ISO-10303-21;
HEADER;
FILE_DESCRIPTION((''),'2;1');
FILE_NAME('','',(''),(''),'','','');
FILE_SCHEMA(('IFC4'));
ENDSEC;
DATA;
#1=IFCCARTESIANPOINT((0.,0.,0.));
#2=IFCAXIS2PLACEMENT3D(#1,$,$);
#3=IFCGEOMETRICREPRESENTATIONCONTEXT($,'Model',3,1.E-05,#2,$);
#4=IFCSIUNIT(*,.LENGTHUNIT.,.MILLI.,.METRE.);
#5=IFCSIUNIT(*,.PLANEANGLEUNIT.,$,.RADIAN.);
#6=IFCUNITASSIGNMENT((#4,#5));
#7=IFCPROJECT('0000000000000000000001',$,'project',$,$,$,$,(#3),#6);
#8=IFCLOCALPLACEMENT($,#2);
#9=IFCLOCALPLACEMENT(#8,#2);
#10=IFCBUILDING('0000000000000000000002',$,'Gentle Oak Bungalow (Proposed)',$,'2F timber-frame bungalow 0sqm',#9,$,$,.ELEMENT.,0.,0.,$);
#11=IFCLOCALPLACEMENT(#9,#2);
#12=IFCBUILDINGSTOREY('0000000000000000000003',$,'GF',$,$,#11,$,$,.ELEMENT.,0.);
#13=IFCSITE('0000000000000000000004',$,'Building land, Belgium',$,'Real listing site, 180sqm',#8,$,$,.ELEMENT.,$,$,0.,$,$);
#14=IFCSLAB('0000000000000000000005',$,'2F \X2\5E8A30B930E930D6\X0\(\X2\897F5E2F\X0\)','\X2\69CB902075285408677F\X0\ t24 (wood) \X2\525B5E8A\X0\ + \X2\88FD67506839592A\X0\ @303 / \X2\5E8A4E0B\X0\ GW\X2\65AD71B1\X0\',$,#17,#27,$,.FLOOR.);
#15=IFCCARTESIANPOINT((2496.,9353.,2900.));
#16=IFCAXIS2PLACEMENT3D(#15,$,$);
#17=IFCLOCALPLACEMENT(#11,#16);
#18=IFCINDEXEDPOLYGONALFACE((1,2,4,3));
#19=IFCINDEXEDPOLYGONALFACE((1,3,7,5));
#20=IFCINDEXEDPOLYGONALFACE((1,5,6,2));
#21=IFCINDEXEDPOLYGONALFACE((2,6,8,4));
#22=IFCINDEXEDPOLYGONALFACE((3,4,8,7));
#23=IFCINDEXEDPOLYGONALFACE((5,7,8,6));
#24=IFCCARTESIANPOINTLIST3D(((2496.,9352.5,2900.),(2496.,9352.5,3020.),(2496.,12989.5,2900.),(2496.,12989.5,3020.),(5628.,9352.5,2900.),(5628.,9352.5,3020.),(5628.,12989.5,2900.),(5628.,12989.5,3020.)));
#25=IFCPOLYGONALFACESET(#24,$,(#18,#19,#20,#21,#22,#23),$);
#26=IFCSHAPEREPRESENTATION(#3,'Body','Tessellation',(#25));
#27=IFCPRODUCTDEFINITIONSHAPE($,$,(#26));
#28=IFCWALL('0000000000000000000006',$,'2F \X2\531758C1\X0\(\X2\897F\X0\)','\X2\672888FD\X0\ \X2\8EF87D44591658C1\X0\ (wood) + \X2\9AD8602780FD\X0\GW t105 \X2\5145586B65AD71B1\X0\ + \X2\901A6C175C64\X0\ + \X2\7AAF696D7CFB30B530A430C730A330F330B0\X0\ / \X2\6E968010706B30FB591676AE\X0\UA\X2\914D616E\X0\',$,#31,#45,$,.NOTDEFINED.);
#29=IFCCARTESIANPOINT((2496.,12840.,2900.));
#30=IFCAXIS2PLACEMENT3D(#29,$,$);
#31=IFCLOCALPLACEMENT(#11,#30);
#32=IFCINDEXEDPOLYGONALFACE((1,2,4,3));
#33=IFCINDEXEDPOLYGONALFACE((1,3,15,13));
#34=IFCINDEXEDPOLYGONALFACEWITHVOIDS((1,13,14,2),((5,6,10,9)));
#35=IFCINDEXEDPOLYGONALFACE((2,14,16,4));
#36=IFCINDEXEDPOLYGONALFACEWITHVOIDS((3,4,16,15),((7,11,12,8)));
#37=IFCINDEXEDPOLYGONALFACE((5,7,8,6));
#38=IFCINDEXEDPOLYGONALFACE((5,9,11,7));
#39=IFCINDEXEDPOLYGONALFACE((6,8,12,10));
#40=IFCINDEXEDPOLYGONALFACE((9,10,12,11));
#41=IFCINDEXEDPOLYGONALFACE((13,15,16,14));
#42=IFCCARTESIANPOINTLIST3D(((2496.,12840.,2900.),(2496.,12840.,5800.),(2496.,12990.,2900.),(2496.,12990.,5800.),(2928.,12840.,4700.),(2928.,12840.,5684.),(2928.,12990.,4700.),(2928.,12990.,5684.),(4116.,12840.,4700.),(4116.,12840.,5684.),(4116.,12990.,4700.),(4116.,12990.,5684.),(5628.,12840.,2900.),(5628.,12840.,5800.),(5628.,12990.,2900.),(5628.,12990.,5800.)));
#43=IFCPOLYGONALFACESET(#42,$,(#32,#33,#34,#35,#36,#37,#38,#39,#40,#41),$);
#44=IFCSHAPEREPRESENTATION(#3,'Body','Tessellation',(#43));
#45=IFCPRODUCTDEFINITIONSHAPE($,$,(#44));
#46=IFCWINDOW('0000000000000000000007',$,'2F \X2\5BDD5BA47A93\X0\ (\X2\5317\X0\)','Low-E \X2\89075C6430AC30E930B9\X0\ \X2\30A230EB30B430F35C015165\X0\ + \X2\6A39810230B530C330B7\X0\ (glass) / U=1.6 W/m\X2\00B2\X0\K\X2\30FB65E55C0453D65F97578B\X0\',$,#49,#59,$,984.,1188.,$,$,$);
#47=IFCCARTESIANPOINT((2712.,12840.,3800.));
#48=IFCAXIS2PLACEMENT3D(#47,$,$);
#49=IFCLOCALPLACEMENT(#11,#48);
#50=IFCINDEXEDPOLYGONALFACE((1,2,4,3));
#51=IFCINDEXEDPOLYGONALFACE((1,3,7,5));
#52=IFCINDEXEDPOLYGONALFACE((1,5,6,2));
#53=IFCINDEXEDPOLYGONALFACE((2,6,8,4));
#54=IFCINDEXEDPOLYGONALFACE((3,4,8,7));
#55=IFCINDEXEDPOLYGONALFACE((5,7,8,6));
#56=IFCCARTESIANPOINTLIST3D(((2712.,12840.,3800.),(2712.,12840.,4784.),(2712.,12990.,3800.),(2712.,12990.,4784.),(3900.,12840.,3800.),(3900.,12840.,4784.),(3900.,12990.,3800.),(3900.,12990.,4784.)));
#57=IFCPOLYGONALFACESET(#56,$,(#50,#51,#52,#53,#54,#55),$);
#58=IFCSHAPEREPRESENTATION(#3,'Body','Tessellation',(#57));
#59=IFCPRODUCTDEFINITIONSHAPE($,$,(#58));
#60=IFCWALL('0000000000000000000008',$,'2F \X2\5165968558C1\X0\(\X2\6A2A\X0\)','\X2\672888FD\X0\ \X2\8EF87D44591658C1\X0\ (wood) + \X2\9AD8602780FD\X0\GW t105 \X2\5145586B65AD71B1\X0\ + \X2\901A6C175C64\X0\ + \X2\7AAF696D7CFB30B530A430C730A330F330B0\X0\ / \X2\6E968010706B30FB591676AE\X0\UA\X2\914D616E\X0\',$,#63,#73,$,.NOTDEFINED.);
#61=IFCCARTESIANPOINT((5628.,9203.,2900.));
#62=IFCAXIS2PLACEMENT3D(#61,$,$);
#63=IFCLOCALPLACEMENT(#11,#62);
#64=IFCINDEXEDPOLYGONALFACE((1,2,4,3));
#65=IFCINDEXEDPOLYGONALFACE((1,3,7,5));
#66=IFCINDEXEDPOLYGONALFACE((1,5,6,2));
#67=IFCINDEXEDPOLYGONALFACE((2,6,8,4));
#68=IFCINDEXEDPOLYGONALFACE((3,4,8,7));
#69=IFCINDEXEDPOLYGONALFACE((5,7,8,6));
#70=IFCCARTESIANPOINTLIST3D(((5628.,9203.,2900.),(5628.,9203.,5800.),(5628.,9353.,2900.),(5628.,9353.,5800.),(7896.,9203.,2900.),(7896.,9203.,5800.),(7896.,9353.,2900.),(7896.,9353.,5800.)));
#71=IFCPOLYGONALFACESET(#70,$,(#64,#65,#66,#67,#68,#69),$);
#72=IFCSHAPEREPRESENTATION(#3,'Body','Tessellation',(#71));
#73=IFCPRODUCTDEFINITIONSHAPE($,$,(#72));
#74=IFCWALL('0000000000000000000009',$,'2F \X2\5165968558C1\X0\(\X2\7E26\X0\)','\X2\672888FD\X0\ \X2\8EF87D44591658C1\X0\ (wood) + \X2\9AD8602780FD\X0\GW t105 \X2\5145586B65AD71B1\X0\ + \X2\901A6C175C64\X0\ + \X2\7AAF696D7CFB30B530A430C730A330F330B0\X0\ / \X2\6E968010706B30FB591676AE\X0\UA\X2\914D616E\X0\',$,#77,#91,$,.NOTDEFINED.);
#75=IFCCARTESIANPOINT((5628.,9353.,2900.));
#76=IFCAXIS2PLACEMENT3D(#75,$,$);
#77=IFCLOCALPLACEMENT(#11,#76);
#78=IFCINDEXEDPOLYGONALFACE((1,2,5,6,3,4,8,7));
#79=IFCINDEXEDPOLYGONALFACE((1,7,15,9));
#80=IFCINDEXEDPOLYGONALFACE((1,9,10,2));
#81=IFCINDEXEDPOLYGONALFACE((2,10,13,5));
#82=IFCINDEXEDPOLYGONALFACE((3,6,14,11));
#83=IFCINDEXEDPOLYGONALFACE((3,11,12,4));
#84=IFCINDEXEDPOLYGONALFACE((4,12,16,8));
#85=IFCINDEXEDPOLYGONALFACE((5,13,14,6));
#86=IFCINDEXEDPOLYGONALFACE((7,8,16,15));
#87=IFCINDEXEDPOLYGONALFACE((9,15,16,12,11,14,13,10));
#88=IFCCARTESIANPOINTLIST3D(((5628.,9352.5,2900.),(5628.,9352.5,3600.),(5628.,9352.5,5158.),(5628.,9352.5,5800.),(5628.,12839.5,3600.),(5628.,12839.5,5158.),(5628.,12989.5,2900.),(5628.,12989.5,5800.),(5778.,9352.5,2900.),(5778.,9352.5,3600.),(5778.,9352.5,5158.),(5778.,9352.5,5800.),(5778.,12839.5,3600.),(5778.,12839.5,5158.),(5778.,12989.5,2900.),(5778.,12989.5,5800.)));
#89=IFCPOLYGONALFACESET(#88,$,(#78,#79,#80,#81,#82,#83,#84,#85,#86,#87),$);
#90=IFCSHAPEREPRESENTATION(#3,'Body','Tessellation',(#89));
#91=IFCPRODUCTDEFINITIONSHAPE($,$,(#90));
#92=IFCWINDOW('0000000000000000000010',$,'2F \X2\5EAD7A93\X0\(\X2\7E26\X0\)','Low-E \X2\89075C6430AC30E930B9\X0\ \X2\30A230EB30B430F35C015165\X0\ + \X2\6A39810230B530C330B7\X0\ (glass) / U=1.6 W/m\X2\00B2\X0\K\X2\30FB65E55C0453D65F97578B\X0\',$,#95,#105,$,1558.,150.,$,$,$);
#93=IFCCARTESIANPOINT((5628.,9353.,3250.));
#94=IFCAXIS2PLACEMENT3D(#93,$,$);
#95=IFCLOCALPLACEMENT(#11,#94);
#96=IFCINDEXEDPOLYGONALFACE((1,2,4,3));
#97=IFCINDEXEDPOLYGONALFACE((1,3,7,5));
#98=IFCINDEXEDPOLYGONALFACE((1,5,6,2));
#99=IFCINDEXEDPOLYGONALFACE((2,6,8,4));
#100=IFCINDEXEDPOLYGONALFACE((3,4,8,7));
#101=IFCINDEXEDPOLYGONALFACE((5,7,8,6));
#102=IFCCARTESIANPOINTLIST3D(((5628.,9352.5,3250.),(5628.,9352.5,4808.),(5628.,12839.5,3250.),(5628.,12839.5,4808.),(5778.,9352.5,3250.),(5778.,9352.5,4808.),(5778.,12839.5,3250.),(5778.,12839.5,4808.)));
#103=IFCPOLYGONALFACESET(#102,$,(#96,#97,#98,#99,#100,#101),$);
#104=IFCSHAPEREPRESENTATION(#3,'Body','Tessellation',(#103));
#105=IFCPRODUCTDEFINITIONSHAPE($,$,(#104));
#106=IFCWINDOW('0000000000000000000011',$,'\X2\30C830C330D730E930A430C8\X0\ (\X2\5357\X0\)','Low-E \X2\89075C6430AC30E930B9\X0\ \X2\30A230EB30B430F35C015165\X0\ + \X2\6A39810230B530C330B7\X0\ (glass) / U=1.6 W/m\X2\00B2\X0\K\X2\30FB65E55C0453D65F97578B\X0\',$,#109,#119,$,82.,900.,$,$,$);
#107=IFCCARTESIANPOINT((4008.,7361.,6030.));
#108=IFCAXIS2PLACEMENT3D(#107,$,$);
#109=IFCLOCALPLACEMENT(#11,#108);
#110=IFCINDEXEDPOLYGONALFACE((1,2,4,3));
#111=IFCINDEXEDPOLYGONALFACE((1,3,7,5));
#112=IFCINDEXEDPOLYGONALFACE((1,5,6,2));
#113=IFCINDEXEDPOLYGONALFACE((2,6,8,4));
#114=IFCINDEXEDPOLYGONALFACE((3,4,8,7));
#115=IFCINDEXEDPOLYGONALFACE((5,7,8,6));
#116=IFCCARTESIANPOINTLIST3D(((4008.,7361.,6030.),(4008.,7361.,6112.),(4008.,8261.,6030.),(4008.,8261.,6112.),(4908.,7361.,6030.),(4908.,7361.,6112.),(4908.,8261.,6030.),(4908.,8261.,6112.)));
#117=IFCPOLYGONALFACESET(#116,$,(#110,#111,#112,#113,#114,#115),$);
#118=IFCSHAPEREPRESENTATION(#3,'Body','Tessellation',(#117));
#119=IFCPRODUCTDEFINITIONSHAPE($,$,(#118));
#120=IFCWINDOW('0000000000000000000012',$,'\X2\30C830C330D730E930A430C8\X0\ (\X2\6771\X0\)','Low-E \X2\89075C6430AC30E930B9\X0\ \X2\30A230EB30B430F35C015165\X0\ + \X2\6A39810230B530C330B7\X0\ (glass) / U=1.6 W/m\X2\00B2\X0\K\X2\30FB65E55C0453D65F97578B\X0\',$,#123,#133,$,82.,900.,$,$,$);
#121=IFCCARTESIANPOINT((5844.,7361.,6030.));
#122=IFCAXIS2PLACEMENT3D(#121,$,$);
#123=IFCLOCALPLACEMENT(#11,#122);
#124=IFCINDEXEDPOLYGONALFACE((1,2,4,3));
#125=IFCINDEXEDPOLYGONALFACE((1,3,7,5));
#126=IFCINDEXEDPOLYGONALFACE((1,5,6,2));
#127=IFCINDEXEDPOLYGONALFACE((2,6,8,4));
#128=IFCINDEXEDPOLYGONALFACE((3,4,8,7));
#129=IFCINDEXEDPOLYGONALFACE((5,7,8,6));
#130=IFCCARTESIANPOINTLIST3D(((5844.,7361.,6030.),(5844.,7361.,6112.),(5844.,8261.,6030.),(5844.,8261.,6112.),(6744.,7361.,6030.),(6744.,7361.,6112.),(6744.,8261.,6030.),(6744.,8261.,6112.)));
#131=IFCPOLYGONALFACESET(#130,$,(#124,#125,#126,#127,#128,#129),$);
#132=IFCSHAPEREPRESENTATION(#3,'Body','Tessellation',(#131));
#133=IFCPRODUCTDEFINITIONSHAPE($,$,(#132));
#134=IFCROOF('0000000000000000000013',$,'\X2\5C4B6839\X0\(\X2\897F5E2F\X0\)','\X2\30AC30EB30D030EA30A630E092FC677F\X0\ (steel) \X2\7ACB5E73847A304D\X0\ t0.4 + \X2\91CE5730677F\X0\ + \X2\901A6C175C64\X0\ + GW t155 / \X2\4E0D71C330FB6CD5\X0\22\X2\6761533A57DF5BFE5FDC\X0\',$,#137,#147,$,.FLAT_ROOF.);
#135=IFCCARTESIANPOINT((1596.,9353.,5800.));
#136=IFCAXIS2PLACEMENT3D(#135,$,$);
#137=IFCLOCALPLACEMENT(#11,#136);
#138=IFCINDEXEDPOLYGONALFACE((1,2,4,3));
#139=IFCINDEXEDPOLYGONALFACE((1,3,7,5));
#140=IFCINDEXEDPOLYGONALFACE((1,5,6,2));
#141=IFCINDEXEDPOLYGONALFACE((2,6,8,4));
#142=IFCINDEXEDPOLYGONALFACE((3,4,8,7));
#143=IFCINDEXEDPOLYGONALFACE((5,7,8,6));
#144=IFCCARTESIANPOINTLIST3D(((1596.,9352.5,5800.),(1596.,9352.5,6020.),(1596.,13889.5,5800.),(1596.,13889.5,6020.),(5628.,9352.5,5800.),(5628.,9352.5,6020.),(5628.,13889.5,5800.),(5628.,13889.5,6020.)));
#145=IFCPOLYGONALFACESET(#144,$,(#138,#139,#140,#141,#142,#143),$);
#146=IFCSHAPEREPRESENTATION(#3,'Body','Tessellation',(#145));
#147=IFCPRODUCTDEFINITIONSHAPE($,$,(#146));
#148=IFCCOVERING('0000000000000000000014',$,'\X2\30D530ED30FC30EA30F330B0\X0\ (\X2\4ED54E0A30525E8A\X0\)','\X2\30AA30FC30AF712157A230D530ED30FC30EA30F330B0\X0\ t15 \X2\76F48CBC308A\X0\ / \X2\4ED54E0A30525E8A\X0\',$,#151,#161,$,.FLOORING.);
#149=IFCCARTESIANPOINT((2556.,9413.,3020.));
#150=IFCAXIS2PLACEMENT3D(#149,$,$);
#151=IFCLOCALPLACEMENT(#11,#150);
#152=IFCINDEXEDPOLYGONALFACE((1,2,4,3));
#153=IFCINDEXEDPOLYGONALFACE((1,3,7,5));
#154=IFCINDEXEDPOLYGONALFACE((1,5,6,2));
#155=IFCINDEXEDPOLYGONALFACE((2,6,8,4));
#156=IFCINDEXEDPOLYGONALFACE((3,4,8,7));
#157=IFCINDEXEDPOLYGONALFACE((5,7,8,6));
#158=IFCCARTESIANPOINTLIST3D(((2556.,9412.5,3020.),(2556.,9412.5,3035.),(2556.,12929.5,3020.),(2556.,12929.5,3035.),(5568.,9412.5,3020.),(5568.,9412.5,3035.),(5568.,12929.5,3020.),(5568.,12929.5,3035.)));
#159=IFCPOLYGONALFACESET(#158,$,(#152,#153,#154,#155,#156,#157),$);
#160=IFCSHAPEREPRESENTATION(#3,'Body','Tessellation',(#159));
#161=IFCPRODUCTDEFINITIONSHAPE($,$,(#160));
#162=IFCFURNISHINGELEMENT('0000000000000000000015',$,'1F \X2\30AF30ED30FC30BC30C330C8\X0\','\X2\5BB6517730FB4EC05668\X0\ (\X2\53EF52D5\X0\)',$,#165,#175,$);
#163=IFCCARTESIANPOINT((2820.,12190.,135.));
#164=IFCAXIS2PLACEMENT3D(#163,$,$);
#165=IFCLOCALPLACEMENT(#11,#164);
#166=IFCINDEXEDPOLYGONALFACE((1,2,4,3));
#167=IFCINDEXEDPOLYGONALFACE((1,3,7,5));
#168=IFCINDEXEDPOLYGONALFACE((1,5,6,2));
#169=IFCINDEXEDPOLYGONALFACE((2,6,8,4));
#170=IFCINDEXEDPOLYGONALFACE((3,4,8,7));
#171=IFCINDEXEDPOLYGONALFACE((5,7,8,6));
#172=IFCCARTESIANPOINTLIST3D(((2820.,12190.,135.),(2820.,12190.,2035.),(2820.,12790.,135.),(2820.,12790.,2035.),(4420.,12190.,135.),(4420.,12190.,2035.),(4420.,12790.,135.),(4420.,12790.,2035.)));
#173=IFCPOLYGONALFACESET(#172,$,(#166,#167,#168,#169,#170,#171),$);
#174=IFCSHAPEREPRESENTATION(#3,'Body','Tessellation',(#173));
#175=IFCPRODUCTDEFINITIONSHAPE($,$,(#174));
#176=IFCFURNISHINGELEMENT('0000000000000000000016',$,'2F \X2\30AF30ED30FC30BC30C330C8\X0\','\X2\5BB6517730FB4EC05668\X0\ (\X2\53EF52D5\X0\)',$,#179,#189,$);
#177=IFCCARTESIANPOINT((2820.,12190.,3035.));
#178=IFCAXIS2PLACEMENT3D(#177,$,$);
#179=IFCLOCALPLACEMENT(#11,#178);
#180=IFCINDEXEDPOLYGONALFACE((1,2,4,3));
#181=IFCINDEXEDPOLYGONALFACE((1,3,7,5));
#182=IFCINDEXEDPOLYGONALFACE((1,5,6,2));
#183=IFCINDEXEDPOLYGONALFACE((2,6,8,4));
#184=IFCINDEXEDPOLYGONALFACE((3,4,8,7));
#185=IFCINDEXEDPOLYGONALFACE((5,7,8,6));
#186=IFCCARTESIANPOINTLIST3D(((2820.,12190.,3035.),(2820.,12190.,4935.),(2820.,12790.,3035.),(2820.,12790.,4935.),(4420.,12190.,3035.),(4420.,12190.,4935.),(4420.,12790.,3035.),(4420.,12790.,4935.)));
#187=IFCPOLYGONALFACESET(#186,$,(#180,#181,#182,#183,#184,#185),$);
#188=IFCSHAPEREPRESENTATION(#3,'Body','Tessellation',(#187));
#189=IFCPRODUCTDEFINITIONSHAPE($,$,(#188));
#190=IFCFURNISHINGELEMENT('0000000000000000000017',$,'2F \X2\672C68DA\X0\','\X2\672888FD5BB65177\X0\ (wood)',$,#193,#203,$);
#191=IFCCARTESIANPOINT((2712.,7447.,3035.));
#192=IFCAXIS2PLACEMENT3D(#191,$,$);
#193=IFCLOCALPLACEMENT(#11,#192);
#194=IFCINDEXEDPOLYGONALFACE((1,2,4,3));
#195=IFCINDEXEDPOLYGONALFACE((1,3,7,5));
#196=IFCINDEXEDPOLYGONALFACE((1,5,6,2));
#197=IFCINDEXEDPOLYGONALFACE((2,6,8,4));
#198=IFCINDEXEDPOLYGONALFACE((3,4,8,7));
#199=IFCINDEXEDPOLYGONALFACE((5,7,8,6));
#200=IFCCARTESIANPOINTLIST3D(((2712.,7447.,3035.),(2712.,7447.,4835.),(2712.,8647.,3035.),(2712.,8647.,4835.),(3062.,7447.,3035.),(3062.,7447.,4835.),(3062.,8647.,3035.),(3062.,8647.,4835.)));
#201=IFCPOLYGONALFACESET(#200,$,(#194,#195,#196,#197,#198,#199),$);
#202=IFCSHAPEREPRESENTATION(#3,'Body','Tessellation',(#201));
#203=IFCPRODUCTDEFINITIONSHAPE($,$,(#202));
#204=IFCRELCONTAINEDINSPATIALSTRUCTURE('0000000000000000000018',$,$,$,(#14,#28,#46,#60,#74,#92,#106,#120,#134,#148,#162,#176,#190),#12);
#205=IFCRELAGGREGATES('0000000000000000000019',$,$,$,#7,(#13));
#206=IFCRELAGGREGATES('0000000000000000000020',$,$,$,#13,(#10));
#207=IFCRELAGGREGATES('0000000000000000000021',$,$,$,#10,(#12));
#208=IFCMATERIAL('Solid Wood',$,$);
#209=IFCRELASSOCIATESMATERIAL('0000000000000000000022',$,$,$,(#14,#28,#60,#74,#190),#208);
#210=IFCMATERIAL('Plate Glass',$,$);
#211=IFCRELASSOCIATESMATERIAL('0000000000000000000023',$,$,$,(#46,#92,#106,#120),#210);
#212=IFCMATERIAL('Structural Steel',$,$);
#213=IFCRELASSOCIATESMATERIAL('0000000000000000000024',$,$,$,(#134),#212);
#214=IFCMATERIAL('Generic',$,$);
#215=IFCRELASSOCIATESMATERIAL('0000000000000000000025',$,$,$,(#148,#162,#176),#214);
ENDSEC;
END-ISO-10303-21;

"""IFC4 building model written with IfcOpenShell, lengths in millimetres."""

from ifc_helpers import new_model, si_unit, frame, frame_2d, origin, place, context, project, spatial, rectangle, extrude, material, element, fill, save


model = new_model("IFC4")

# Units and contexts
model_context = context("Model", 3, precision=1e-05, world=origin())
ifc_project = project(units=[si_unit("LENGTHUNIT", "METRE", prefix="MILLI"), si_unit("PLANEANGLEUNIT", "RADIAN")], contexts=[model_context])

# Site, building, storey
site_placement = place(None, origin())
site = spatial("IfcSite", under=ifc_project, at=site_placement, Name="Building land, Belgium", ObjectType="Real listing site, 180sqm", CompositionType="ELEMENT", RefElevation=0.0)
building_placement = place(site_placement, origin())
building = spatial("IfcBuilding", under=site, at=building_placement, Name="Gentle Oak Bungalow (Proposed)", ObjectType="2F timber-frame bungalow 0sqm", CompositionType="ELEMENT", ElevationOfRefHeight=0.0, ElevationOfTerrain=0.0)
storey_placement = place(building_placement, origin())
storey = spatial("IfcBuildingStorey", under=building, at=storey_placement, Name="GF", CompositionType="ELEMENT", Elevation=0.0)

# Slab
ifc_material_1 = material(Name="Solid Wood")
slab_placement = place(storey_placement, frame((2496.0, 9353.0, 2900.0)))
element("IfcSlab", 1, at=slab_placement, inside=storey, material=ifc_material_1, Name="2F 床スラブ(西帯)", Description="構造用合板 t24 (wood) 剛床 + 製材根太 @303 / 床下 GW断熱", PredefinedType="FLOOR", context=model_context, shape_type="SweptSolid", body=[
    extrude(rectangle(XDim=3132.0, YDim=3637.0, at=frame_2d((1566.0, 1818.0))), frame((2496.0, 9353.0, 2900.0)), (0.0, 0.0, 1.0), 120.0),
])

# Wall, opening, window
wall_1_placement = place(storey_placement, frame((2496.0, 12840.0, 2900.0)))
wall_1 = element("IfcWall", 2, at=wall_1_placement, inside=storey, material=ifc_material_1, Name="2F 北壁(西)", Description="木製 軸組外壁 (wood) + 高性能GW t105 充填断熱 + 通気層 + 窯業系サイディング / 準耐火・外皮UA配慮", PredefinedType="NOTDEFINED", context=model_context, shape_type="SweptSolid", body=[
    extrude(rectangle(XDim=3132.0, YDim=150.0, at=frame_2d((1566.0, 75.0))), frame((2496.0, 12840.0, 2900.0)), (0.0, 0.0, 1.0), 2900.0),
])
opening_1_placement = place(storey_placement, frame((2712.0, 12840.0, 3800.0)))
opening_1 = element("IfcOpeningElement", 3, at=opening_1_placement, cuts=wall_1, PredefinedType="NOTDEFINED", context=model_context, shape_type="SweptSolid", body=[
    extrude(rectangle(XDim=1188.0, YDim=150.0, at=frame_2d((594.0, 75.0))), frame((2712.0, 12840.0, 3800.0)), (0.0, 0.0, 1.0), 984.0),
])
ifc_material_2 = material(Name="Plate Glass")
window_1_placement = place(storey_placement, frame((2712.0, 12840.0, 3800.0)))
window_1 = element("IfcWindow", 4, at=window_1_placement, inside=storey, material=ifc_material_2, Name="2F 寝室窓 (北)", Description="Low-E 複層ガラス アルゴン封入 + 樹脂サッシ (glass) / U=1.6 W/m²K・日射取得型", OverallHeight=984.0, OverallWidth=1188.0, context=model_context, shape_type="SweptSolid", body=[
    extrude(rectangle(XDim=1188.0, YDim=150.0, at=frame_2d((594.0, 75.0))), frame((2712.0, 12840.0, 3800.0)), (0.0, 0.0, 1.0), 984.0),
])
fill(opening_1, window_1)

# Wall
wall_2_placement = place(storey_placement, frame((5628.0, 9203.0, 2900.0)))
element("IfcWall", 5, at=wall_2_placement, inside=storey, material=ifc_material_1, Name="2F 入隅壁(横)", Description="木製 軸組外壁 (wood) + 高性能GW t105 充填断熱 + 通気層 + 窯業系サイディング / 準耐火・外皮UA配慮", PredefinedType="NOTDEFINED", context=model_context, shape_type="SweptSolid", body=[
    extrude(rectangle(XDim=2268.0, YDim=150.0, at=frame_2d((1134.0, 75.0))), frame((5628.0, 9203.0, 2900.0)), (0.0, 0.0, 1.0), 2900.0),
])

# Wall, opening, window
wall_3_placement = place(storey_placement, frame((5628.0, 9353.0, 2900.0)))
wall_3 = element("IfcWall", 6, at=wall_3_placement, inside=storey, material=ifc_material_1, Name="2F 入隅壁(縦)", Description="木製 軸組外壁 (wood) + 高性能GW t105 充填断熱 + 通気層 + 窯業系サイディング / 準耐火・外皮UA配慮", PredefinedType="NOTDEFINED", context=model_context, shape_type="SweptSolid", body=[
    extrude(rectangle(XDim=150.0, YDim=3637.0, at=frame_2d((75.0, 1818.0))), frame((5628.0, 9353.0, 2900.0)), (0.0, 0.0, 1.0), 2900.0),
])
opening_2_placement = place(storey_placement, frame((5628.0, 9353.0, 3250.0)))
opening_2 = element("IfcOpeningElement", 7, at=opening_2_placement, cuts=wall_3, PredefinedType="NOTDEFINED", context=model_context, shape_type="SweptSolid", body=[
    extrude(rectangle(XDim=150.0, YDim=3487.0, at=frame_2d((75.0, 1743.0))), frame((5628.0, 9353.0, 3250.0)), (0.0, 0.0, 1.0), 1558.0),
])
window_2_placement = place(storey_placement, frame((5628.0, 9353.0, 3250.0)))
window_2 = element("IfcWindow", 8, at=window_2_placement, inside=storey, material=ifc_material_2, Name="2F 庭窓(縦)", Description="Low-E 複層ガラス アルゴン封入 + 樹脂サッシ (glass) / U=1.6 W/m²K・日射取得型", OverallHeight=1558.0, OverallWidth=150.0, context=model_context, shape_type="SweptSolid", body=[
    extrude(rectangle(XDim=150.0, YDim=3487.0, at=frame_2d((75.0, 1743.0))), frame((5628.0, 9353.0, 3250.0)), (0.0, 0.0, 1.0), 1558.0),
])
fill(opening_2, window_2)

# Windows
window_3_placement = place(storey_placement, frame((4008.0, 7361.0, 6030.0)))
element("IfcWindow", 9, at=window_3_placement, inside=storey, material=ifc_material_2, Name="トップライト (南)", Description="Low-E 複層ガラス アルゴン封入 + 樹脂サッシ (glass) / U=1.6 W/m²K・日射取得型", OverallHeight=82.0, OverallWidth=900.0, context=model_context, shape_type="SweptSolid", body=[
    extrude(rectangle(XDim=900.0, YDim=900.0, at=frame_2d((450.0, 450.0))), frame((4008.0, 7361.0, 6030.0)), (0.0, 0.0, 1.0), 82.0),
])
window_4_placement = place(storey_placement, frame((5844.0, 7361.0, 6030.0)))
element("IfcWindow", 10, at=window_4_placement, inside=storey, material=ifc_material_2, Name="トップライト (東)", Description="Low-E 複層ガラス アルゴン封入 + 樹脂サッシ (glass) / U=1.6 W/m²K・日射取得型", OverallHeight=82.0, OverallWidth=900.0, context=model_context, shape_type="SweptSolid", body=[
    extrude(rectangle(XDim=900.0, YDim=900.0, at=frame_2d((450.0, 450.0))), frame((5844.0, 7361.0, 6030.0)), (0.0, 0.0, 1.0), 82.0),
])

# Roof
ifc_material_3 = material(Name="Structural Steel")
for number, where, name in (
    (11, (1596.0, 9353.0, 5800.0), "屋根(西帯)"),
):
    element("IfcRoof", number, at=place(storey_placement, frame(where)), inside=storey, material=ifc_material_3, Name=name, Description="ガルバリウム鋼板 (steel) 立平葺き t0.4 + 野地板 + 通気層 + GW t155 / 不燃・法22条区域対応", PredefinedType="FLAT_ROOF", context=model_context, shape_type="SweptSolid", body=[
        extrude(rectangle(XDim=4032.0, YDim=4537.0, at=frame_2d((2016.0, 2268.0))), frame((1596.0, 9353.0, 5800.0)), (0.0, 0.0, 1.0), 220.0),
    ])

# Covering
ifc_material_4 = material(Name="Generic")
covering_placement = place(storey_placement, frame((2556.0, 9413.0, 3020.0)))
element("IfcCovering", 12, at=covering_placement, inside=storey, material=ifc_material_4, Name="フローリング (仕上げ床)", Description="オーク無垢フローリング t15 直貼り / 仕上げ床", PredefinedType="FLOORING", context=model_context, shape_type="SweptSolid", body=[
    extrude(rectangle(XDim=3012.0, YDim=3517.0, at=frame_2d((1506.0, 1758.0))), frame((2556.0, 9413.0, 3020.0)), (0.0, 0.0, 1.0), 15.0),
])

# Furnishing elements
furnishing_1_placement = place(storey_placement, frame((2820.0, 12190.0, 135.0)))
element("IfcFurnishingElement", 13, at=furnishing_1_placement, inside=storey, material=ifc_material_4, Name="1F クローゼット", Description="家具・什器 (可動)", context=model_context, shape_type="SweptSolid", body=[
    extrude(rectangle(XDim=1600.0, YDim=600.0, at=frame_2d((800.0, 300.0))), frame((2820.0, 12190.0, 135.0)), (0.0, 0.0, 1.0), 1900.0),
])
furnishing_2_placement = place(storey_placement, frame((2820.0, 12190.0, 3035.0)))
element("IfcFurnishingElement", 14, at=furnishing_2_placement, inside=storey, material=ifc_material_4, Name="2F クローゼット", Description="家具・什器 (可動)", context=model_context, shape_type="SweptSolid", body=[
    extrude(rectangle(XDim=1600.0, YDim=600.0, at=frame_2d((800.0, 300.0))), frame((2820.0, 12190.0, 3035.0)), (0.0, 0.0, 1.0), 1900.0),
])
furnishing_3_placement = place(storey_placement, frame((2712.0, 7447.0, 3035.0)))
element("IfcFurnishingElement", 15, at=furnishing_3_placement, inside=storey, material=ifc_material_1, Name="2F 本棚", Description="木製家具 (wood)", context=model_context, shape_type="SweptSolid", body=[
    extrude(rectangle(XDim=350.0, YDim=1200.0, at=frame_2d((175.0, 600.0))), frame((2712.0, 7447.0, 3035.0)), (0.0, 0.0, 1.0), 1800.0),
])

save(model, "model.ifc")
